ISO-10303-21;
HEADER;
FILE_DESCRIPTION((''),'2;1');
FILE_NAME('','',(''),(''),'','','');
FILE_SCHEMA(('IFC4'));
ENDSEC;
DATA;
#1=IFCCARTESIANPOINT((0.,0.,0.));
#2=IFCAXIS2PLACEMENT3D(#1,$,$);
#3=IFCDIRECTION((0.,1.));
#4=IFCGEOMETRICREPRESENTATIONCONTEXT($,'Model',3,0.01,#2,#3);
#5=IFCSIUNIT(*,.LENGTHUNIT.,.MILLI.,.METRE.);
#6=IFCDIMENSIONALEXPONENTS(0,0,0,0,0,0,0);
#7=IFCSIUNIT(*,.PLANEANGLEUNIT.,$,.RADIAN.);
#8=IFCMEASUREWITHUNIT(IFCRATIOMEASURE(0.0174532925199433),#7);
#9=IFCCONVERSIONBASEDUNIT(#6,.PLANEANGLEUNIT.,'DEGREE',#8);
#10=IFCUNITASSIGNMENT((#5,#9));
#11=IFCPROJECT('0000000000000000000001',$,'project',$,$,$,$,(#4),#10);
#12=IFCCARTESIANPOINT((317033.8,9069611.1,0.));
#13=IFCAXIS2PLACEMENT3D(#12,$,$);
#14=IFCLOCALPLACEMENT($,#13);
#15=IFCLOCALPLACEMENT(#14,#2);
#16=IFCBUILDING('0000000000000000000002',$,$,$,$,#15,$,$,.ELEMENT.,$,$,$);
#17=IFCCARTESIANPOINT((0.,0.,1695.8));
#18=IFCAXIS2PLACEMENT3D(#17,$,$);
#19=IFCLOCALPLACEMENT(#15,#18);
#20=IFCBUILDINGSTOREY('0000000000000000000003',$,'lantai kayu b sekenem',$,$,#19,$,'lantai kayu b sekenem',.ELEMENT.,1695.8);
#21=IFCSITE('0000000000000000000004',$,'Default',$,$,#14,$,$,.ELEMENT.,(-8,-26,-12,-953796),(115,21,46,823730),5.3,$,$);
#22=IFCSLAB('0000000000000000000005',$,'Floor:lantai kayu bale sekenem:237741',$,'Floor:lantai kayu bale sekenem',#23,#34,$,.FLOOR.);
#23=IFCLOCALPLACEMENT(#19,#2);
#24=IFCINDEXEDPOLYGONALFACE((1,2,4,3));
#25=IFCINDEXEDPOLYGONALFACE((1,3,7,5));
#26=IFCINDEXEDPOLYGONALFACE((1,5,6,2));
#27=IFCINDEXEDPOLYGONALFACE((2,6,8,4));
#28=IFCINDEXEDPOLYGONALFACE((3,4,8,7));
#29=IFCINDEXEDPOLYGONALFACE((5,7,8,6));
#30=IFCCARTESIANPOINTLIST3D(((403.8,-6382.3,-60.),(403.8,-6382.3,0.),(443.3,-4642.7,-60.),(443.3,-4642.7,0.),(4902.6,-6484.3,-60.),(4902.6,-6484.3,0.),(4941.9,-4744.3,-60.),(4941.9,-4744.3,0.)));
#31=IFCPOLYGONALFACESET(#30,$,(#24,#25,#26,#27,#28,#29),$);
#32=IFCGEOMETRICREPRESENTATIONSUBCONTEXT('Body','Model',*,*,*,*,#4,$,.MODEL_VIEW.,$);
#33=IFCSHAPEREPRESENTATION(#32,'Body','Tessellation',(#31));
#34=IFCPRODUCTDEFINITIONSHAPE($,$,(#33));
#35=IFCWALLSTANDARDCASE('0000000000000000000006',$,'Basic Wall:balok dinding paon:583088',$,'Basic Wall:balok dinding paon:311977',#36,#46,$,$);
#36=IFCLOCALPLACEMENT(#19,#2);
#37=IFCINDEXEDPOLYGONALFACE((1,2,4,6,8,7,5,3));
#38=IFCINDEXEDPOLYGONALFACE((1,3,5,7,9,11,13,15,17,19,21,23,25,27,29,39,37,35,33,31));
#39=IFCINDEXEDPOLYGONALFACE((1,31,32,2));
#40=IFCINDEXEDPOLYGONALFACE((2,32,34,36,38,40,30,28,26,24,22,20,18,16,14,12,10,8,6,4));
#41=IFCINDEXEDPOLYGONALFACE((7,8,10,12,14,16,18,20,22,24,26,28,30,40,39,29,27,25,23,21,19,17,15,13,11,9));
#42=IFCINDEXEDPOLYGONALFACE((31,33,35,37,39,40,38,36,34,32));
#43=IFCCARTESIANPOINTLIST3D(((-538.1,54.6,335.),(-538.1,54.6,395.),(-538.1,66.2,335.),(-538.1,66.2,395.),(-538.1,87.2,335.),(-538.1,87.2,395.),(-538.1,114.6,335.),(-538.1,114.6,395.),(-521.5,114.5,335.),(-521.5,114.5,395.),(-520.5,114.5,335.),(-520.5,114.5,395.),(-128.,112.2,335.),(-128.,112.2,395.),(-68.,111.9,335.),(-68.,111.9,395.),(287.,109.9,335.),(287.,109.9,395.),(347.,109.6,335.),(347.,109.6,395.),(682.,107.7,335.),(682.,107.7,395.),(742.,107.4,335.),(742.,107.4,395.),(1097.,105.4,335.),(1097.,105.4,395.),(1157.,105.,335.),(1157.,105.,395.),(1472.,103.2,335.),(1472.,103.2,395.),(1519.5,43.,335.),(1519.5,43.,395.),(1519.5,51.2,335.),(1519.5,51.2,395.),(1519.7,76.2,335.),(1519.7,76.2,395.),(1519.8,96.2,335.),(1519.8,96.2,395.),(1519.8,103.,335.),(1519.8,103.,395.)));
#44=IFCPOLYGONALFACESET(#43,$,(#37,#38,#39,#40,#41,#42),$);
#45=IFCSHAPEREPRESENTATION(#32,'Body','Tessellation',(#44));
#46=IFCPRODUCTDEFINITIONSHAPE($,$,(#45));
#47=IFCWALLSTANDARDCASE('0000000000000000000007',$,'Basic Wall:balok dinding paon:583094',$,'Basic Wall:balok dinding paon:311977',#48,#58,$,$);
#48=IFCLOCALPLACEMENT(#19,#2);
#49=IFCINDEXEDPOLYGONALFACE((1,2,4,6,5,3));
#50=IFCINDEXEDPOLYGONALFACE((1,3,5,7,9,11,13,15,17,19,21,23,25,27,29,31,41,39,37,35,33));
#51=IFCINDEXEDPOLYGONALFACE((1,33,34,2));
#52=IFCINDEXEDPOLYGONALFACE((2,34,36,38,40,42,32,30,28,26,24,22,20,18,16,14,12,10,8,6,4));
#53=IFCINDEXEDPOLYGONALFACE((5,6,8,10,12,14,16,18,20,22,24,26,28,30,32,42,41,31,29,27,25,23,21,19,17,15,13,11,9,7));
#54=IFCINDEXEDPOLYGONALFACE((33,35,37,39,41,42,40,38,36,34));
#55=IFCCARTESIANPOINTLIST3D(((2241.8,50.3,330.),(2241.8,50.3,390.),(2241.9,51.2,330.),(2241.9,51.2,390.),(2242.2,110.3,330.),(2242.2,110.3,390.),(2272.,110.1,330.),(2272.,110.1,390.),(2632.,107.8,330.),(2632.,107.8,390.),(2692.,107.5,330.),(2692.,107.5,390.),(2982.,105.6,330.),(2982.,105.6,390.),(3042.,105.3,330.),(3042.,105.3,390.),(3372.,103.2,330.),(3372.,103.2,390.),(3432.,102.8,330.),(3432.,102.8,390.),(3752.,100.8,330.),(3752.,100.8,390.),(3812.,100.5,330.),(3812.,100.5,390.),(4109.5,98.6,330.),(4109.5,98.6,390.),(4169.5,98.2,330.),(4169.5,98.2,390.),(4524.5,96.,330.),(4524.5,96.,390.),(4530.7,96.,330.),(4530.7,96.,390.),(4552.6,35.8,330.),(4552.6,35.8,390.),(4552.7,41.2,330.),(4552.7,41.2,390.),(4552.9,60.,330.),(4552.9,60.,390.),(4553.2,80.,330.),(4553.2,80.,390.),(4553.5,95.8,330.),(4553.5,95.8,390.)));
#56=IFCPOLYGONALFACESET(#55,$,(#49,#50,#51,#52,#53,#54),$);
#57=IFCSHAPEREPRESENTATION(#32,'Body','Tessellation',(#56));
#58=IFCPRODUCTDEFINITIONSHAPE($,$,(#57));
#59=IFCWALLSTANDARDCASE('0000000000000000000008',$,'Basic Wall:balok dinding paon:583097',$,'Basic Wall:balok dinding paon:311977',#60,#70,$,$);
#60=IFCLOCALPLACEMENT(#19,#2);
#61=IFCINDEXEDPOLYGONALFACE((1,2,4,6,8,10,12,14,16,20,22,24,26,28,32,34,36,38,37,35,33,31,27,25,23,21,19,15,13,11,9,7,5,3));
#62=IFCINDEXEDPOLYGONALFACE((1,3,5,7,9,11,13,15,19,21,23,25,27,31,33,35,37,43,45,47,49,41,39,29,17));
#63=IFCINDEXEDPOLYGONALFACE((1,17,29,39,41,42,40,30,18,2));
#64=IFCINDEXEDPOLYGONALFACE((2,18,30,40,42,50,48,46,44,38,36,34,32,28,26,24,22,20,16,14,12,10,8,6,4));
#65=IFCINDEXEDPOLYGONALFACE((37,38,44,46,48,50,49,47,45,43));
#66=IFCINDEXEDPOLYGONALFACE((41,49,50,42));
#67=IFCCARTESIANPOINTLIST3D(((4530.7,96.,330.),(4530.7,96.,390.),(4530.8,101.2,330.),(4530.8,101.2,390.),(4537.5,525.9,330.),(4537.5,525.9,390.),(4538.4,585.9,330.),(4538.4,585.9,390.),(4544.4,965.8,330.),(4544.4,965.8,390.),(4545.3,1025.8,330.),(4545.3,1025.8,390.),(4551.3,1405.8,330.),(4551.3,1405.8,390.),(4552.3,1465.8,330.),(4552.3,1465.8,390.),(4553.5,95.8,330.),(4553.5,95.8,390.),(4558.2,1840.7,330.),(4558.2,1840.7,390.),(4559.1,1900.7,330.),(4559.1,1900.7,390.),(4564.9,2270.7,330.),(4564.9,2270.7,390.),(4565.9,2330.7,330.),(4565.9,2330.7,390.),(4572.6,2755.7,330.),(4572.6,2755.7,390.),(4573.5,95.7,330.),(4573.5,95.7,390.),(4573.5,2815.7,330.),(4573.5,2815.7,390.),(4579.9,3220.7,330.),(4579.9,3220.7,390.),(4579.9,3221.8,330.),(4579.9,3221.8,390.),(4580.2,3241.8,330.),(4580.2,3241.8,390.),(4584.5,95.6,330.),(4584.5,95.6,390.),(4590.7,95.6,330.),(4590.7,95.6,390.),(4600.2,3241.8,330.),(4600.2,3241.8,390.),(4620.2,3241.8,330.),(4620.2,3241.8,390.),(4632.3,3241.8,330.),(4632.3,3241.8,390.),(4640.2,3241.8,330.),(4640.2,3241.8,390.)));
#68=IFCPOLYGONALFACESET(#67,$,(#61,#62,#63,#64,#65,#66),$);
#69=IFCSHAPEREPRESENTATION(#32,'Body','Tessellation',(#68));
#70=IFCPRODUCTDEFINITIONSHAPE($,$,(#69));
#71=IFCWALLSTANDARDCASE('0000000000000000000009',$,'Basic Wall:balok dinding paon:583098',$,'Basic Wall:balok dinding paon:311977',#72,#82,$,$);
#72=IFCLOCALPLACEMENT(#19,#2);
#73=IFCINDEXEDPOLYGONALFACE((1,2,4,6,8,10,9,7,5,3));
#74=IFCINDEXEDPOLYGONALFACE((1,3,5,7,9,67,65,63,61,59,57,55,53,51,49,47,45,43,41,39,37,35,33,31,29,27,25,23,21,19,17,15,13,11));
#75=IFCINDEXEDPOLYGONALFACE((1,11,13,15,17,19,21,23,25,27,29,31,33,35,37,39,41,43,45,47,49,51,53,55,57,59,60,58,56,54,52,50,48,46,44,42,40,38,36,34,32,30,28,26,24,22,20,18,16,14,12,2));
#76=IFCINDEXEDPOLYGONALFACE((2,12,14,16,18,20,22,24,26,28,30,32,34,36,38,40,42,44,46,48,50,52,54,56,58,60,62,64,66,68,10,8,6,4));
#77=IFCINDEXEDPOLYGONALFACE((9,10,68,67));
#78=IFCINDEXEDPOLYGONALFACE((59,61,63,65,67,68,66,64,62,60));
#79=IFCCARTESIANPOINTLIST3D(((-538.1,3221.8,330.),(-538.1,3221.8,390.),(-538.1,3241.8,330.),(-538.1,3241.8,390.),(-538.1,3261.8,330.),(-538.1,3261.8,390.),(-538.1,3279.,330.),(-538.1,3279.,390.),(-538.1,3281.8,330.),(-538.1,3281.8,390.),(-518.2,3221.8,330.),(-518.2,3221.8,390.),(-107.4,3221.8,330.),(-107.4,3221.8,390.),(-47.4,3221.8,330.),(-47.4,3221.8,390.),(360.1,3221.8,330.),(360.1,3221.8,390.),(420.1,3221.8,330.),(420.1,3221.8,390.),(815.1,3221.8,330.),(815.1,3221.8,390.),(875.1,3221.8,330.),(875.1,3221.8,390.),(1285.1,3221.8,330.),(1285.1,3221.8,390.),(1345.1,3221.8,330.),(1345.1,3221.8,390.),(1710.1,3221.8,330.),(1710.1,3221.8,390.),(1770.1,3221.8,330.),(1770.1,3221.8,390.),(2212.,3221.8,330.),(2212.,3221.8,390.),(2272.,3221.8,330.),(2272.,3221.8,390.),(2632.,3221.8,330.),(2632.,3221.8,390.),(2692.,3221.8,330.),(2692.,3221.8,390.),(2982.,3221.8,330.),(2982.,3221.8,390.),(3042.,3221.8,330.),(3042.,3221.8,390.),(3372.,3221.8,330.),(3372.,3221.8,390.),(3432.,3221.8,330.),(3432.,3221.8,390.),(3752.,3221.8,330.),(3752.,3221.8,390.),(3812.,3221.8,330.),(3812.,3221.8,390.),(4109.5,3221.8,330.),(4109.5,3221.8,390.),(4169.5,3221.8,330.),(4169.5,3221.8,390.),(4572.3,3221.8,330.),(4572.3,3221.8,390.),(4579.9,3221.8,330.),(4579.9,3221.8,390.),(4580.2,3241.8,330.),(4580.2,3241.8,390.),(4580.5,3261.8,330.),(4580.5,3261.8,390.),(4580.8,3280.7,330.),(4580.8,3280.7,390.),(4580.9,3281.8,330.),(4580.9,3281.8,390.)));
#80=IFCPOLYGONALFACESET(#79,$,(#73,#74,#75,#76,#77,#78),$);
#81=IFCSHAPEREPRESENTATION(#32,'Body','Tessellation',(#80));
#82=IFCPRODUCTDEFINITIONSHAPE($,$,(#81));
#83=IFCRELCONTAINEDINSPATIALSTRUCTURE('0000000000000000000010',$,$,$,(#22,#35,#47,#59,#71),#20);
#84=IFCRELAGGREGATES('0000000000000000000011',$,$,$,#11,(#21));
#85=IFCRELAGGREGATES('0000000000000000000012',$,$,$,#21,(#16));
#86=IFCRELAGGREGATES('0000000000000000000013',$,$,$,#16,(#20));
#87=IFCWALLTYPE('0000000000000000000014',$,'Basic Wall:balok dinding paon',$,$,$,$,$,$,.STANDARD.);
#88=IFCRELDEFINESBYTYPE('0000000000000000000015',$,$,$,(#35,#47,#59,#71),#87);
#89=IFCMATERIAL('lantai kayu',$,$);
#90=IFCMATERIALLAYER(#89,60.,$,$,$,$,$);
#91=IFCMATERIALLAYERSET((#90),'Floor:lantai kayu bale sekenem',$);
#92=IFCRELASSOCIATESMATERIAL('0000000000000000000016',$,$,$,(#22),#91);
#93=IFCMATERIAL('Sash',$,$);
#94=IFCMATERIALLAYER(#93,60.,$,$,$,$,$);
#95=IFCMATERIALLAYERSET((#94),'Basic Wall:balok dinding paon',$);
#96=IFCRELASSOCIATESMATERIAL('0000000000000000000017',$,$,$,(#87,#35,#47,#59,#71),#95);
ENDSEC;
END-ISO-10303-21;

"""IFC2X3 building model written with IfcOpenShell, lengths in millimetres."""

from ifc_helpers import new_model, entity, si_unit, converted_unit, direction, frame, origin, place, context, subcontext, project, spatial, polyline, outline, extrude, material, layer, layer_set, layer_usage, type_object, element, save


model = new_model("IFC2X3")

# Units and contexts
model_context = context("Model", 3, precision=0.01, world=origin(), true_north=direction((0.0, 1.0)))
body_context = subcontext(model_context, "Body", "Model", "MODEL_VIEW")
ifc_project = project(units=[si_unit("LENGTHUNIT", "METRE", prefix="MILLI"), converted_unit("PLANEANGLEUNIT", "DEGREE", entity("IfcRatioMeasure", 0.0174532925199433), si_unit("PLANEANGLEUNIT", "RADIAN"), dimensions=[0, 0, 0, 0, 0, 0, 0])], contexts=[model_context])

# Site, building, storey
site_placement = place(None, frame((317033.8, 9069611.1, 0.0)))
site = spatial("IfcSite", under=ifc_project, at=site_placement, Name="Default", CompositionType="ELEMENT", RefLatitude=(-8, -26, -12, -953796), RefLongitude=(115, 21, 46, 823730), RefElevation=5.3)
building_placement = place(site_placement, origin())
building = spatial("IfcBuilding", under=site, at=building_placement, CompositionType="ELEMENT")
storey_placement = place(building_placement, frame((0.0, 0.0, 1695.8)))
storey = spatial("IfcBuildingStorey", under=building, at=storey_placement, Name="lantai kayu b sekenem", LongName="lantai kayu b sekenem", CompositionType="ELEMENT", Elevation=1695.8)

# Slab
ifc_material_1 = material(Name="lantai kayu")
ifc_layer_1 = layer(ifc_material_1, 60.0)
ifc_layer_set_1 = layer_set([ifc_layer_1], Name="Floor:lantai kayu bale sekenem")
ifc_layer_usage_1 = layer_usage(ifc_layer_set_1, "AXIS3", "POSITIVE", 0.0)
slab_placement = place(storey_placement, origin())
element("IfcSlab", 1, at=slab_placement, inside=storey, material=ifc_layer_usage_1, Name="Floor:lantai kayu bale sekenem:237741", ObjectType="Floor:lantai kayu bale sekenem", PredefinedType="FLOOR", context=body_context, shape_type="SweptSolid", body=[
    extrude(outline(polyline([(-2249.9, -870.1), (2250.0, -870.1), (2250.0, 870.3), (-2250.0, 869.9), (-2249.9, -870.1)])), frame((2672.9, -5563.4, 0.0), z_axis=(0.0, 0.0, -1.0), x_axis=(0.999745, -0.022583, 0.0)), (0.0, 0.0, 1.0), 60.0),
])

# Walls
ifc_material_2 = material(Name="Sash")
ifc_layer_2 = layer(ifc_material_2, 60.0)
ifc_layer_set_2 = layer_set([ifc_layer_2], Name="Basic Wall:balok dinding paon")
ifc_layer_usage_2 = layer_usage(ifc_layer_set_2, "AXIS2", "NEGATIVE", 30.0)
wall_type = type_object("IfcWallType", Name="Basic Wall:balok dinding paon", PredefinedType="STANDARD", material=ifc_layer_set_2)
wall_1_placement = place(storey_placement, frame((-538.3, 84.6, 335.0), z_axis=(0.0, 0.0, 1.0), x_axis=(0.999984, -0.005623, 0.0)))
element("IfcWallStandardCase", 2, at=wall_1_placement, inside=storey, type_object=wall_type, material=ifc_layer_usage_2, Name="Basic Wall:balok dinding paon:583088", ObjectType="Basic Wall:balok dinding paon:311977", context=body_context, shape_type="SweptSolid", body=[
    extrude(outline(polyline([(2057.9, -30.0), (2057.9, -21.8), (2057.9, 3.2), (2057.9, 23.2), (2057.9, 30.0), (2010.2, 30.0), (1695.2, 30.0), (1635.1, 30.0), (1280.1, 30.0), (1220.1, 30.0), (885.1, 30.0), (825.1, 30.0), (470.1, 30.0), (410.1, 30.0), (17.6, 30.0), (16.6, 30.0), (0.0, 30.0), (0.2, 2.7), (0.3, -18.4), (0.3, -30.0), (2057.9, -30.0)])), origin(), (0.0, 0.0, 1.0), 60.0),
])
ifc_layer_usage_3 = layer_usage(ifc_layer_set_2, "AXIS2", "NEGATIVE", 30.0)
wall_2_placement = place(storey_placement, frame((2242.0, 80.3, 330.0), z_axis=(0.0, 0.0, 1.0), x_axis=(0.99998, -0.006246, 0.0)))
element("IfcWallStandardCase", 3, at=wall_2_placement, inside=storey, type_object=wall_type, material=ifc_layer_usage_3, Name="Basic Wall:balok dinding paon:583094", ObjectType="Basic Wall:balok dinding paon:311977", context=body_context, shape_type="SweptSolid", body=[
    extrude(outline(polyline([(2310.8, -30.0), (2310.8, -24.7), (2311.0, -5.9), (2311.2, 14.1), (2311.3, 30.0), (2288.5, 30.0), (2282.4, 30.0), (1927.4, 30.0), (1867.3, 30.0), (1569.8, 30.0), (1509.8, 30.0), (1189.8, 30.0), (1129.8, 30.0), (799.8, 30.0), (739.8, 30.0), (449.8, 30.0), (389.8, 30.0), (29.8, 30.0), (0.0, 30.0), (0.0, -29.1), (0.0, -30.0), (2310.8, -30.0)])), origin(), (0.0, 0.0, 1.0), 60.0),
])
ifc_layer_usage_4 = layer_usage(ifc_layer_set_2, "AXIS2", "NEGATIVE", 30.0)
wall_3_placement = place(storey_placement, frame((4610.2, 3242.3, 330.0), z_axis=(0.0, 0.0, 1.0), x_axis=(-0.015744, -0.999876, 0.0)))
element("IfcWallStandardCase", 4, at=wall_3_placement, inside=storey, type_object=wall_type, material=ifc_layer_usage_4, Name="Basic Wall:balok dinding paon:583097", ObjectType="Basic Wall:balok dinding paon:311977", context=body_context, shape_type="SweptSolid", body=[
    extrude(outline(polyline([(3147.2, -30.0), (3147.0, -7.2), (3146.8, 12.8), (3146.7, 23.8), (3146.6, 30.0), (0.0, 30.0), (0.1, 22.1), (0.3, 10.0), (0.6, -10.0), (0.9, -30.0), (20.9, -30.0), (22.0, -30.0), (427.1, -30.0), (487.1, -30.0), (912.1, -30.0), (972.1, -30.0), (1342.2, -30.0), (1402.2, -30.0), (1777.1, -30.0), (1837.2, -30.0), (2217.2, -30.0), (2277.2, -30.0), (2657.2, -30.0), (2717.2, -30.0), (3142.0, -30.0), (3147.2, -30.0)])), origin(), (0.0, 0.0, 1.0), 60.0),
])
ifc_layer_usage_5 = layer_usage(ifc_layer_set_2, "AXIS2", "NEGATIVE", 30.0)
wall_4_placement = place(storey_placement, frame((-538.1, 3251.8, 330.0)))
element("IfcWallStandardCase", 5, at=wall_4_placement, inside=storey, type_object=wall_type, material=ifc_layer_usage_5, Name="Basic Wall:balok dinding paon:583098", ObjectType="Basic Wall:balok dinding paon:311977", context=body_context, shape_type="SweptSolid", body=[
    extrude(outline(polyline([(5118.0, -30.0), (5118.3, -10.0), (5118.6, 10.0), (5118.9, 28.9), (5118.9, 30.0), (0.0, 30.0), (0.0, 27.2), (0.0, 10.0), (0.0, -10.0), (0.0, -30.0), (19.9, -30.0), (430.7, -30.0), (490.7, -30.0), (898.2, -30.0), (958.2, -30.0), (1353.2, -30.0), (1413.2, -30.0), (1823.2, -30.0), (1883.2, -30.0), (2248.2, -30.0), (2308.2, -30.0), (2750.1, -30.0), (2810.1, -30.0), (3170.1, -30.0), (3230.1, -30.0), (3520.1, -30.0), (3580.1, -30.0), (3910.1, -30.0), (3970.1, -30.0), (4290.1, -30.0), (4350.1, -30.0), (4647.6, -30.0), (4707.6, -30.0), (5110.4, -30.0), (5118.0, -30.0)])), origin(), (0.0, 0.0, 1.0), 60.0),
])

save(model, "model.ifc")
